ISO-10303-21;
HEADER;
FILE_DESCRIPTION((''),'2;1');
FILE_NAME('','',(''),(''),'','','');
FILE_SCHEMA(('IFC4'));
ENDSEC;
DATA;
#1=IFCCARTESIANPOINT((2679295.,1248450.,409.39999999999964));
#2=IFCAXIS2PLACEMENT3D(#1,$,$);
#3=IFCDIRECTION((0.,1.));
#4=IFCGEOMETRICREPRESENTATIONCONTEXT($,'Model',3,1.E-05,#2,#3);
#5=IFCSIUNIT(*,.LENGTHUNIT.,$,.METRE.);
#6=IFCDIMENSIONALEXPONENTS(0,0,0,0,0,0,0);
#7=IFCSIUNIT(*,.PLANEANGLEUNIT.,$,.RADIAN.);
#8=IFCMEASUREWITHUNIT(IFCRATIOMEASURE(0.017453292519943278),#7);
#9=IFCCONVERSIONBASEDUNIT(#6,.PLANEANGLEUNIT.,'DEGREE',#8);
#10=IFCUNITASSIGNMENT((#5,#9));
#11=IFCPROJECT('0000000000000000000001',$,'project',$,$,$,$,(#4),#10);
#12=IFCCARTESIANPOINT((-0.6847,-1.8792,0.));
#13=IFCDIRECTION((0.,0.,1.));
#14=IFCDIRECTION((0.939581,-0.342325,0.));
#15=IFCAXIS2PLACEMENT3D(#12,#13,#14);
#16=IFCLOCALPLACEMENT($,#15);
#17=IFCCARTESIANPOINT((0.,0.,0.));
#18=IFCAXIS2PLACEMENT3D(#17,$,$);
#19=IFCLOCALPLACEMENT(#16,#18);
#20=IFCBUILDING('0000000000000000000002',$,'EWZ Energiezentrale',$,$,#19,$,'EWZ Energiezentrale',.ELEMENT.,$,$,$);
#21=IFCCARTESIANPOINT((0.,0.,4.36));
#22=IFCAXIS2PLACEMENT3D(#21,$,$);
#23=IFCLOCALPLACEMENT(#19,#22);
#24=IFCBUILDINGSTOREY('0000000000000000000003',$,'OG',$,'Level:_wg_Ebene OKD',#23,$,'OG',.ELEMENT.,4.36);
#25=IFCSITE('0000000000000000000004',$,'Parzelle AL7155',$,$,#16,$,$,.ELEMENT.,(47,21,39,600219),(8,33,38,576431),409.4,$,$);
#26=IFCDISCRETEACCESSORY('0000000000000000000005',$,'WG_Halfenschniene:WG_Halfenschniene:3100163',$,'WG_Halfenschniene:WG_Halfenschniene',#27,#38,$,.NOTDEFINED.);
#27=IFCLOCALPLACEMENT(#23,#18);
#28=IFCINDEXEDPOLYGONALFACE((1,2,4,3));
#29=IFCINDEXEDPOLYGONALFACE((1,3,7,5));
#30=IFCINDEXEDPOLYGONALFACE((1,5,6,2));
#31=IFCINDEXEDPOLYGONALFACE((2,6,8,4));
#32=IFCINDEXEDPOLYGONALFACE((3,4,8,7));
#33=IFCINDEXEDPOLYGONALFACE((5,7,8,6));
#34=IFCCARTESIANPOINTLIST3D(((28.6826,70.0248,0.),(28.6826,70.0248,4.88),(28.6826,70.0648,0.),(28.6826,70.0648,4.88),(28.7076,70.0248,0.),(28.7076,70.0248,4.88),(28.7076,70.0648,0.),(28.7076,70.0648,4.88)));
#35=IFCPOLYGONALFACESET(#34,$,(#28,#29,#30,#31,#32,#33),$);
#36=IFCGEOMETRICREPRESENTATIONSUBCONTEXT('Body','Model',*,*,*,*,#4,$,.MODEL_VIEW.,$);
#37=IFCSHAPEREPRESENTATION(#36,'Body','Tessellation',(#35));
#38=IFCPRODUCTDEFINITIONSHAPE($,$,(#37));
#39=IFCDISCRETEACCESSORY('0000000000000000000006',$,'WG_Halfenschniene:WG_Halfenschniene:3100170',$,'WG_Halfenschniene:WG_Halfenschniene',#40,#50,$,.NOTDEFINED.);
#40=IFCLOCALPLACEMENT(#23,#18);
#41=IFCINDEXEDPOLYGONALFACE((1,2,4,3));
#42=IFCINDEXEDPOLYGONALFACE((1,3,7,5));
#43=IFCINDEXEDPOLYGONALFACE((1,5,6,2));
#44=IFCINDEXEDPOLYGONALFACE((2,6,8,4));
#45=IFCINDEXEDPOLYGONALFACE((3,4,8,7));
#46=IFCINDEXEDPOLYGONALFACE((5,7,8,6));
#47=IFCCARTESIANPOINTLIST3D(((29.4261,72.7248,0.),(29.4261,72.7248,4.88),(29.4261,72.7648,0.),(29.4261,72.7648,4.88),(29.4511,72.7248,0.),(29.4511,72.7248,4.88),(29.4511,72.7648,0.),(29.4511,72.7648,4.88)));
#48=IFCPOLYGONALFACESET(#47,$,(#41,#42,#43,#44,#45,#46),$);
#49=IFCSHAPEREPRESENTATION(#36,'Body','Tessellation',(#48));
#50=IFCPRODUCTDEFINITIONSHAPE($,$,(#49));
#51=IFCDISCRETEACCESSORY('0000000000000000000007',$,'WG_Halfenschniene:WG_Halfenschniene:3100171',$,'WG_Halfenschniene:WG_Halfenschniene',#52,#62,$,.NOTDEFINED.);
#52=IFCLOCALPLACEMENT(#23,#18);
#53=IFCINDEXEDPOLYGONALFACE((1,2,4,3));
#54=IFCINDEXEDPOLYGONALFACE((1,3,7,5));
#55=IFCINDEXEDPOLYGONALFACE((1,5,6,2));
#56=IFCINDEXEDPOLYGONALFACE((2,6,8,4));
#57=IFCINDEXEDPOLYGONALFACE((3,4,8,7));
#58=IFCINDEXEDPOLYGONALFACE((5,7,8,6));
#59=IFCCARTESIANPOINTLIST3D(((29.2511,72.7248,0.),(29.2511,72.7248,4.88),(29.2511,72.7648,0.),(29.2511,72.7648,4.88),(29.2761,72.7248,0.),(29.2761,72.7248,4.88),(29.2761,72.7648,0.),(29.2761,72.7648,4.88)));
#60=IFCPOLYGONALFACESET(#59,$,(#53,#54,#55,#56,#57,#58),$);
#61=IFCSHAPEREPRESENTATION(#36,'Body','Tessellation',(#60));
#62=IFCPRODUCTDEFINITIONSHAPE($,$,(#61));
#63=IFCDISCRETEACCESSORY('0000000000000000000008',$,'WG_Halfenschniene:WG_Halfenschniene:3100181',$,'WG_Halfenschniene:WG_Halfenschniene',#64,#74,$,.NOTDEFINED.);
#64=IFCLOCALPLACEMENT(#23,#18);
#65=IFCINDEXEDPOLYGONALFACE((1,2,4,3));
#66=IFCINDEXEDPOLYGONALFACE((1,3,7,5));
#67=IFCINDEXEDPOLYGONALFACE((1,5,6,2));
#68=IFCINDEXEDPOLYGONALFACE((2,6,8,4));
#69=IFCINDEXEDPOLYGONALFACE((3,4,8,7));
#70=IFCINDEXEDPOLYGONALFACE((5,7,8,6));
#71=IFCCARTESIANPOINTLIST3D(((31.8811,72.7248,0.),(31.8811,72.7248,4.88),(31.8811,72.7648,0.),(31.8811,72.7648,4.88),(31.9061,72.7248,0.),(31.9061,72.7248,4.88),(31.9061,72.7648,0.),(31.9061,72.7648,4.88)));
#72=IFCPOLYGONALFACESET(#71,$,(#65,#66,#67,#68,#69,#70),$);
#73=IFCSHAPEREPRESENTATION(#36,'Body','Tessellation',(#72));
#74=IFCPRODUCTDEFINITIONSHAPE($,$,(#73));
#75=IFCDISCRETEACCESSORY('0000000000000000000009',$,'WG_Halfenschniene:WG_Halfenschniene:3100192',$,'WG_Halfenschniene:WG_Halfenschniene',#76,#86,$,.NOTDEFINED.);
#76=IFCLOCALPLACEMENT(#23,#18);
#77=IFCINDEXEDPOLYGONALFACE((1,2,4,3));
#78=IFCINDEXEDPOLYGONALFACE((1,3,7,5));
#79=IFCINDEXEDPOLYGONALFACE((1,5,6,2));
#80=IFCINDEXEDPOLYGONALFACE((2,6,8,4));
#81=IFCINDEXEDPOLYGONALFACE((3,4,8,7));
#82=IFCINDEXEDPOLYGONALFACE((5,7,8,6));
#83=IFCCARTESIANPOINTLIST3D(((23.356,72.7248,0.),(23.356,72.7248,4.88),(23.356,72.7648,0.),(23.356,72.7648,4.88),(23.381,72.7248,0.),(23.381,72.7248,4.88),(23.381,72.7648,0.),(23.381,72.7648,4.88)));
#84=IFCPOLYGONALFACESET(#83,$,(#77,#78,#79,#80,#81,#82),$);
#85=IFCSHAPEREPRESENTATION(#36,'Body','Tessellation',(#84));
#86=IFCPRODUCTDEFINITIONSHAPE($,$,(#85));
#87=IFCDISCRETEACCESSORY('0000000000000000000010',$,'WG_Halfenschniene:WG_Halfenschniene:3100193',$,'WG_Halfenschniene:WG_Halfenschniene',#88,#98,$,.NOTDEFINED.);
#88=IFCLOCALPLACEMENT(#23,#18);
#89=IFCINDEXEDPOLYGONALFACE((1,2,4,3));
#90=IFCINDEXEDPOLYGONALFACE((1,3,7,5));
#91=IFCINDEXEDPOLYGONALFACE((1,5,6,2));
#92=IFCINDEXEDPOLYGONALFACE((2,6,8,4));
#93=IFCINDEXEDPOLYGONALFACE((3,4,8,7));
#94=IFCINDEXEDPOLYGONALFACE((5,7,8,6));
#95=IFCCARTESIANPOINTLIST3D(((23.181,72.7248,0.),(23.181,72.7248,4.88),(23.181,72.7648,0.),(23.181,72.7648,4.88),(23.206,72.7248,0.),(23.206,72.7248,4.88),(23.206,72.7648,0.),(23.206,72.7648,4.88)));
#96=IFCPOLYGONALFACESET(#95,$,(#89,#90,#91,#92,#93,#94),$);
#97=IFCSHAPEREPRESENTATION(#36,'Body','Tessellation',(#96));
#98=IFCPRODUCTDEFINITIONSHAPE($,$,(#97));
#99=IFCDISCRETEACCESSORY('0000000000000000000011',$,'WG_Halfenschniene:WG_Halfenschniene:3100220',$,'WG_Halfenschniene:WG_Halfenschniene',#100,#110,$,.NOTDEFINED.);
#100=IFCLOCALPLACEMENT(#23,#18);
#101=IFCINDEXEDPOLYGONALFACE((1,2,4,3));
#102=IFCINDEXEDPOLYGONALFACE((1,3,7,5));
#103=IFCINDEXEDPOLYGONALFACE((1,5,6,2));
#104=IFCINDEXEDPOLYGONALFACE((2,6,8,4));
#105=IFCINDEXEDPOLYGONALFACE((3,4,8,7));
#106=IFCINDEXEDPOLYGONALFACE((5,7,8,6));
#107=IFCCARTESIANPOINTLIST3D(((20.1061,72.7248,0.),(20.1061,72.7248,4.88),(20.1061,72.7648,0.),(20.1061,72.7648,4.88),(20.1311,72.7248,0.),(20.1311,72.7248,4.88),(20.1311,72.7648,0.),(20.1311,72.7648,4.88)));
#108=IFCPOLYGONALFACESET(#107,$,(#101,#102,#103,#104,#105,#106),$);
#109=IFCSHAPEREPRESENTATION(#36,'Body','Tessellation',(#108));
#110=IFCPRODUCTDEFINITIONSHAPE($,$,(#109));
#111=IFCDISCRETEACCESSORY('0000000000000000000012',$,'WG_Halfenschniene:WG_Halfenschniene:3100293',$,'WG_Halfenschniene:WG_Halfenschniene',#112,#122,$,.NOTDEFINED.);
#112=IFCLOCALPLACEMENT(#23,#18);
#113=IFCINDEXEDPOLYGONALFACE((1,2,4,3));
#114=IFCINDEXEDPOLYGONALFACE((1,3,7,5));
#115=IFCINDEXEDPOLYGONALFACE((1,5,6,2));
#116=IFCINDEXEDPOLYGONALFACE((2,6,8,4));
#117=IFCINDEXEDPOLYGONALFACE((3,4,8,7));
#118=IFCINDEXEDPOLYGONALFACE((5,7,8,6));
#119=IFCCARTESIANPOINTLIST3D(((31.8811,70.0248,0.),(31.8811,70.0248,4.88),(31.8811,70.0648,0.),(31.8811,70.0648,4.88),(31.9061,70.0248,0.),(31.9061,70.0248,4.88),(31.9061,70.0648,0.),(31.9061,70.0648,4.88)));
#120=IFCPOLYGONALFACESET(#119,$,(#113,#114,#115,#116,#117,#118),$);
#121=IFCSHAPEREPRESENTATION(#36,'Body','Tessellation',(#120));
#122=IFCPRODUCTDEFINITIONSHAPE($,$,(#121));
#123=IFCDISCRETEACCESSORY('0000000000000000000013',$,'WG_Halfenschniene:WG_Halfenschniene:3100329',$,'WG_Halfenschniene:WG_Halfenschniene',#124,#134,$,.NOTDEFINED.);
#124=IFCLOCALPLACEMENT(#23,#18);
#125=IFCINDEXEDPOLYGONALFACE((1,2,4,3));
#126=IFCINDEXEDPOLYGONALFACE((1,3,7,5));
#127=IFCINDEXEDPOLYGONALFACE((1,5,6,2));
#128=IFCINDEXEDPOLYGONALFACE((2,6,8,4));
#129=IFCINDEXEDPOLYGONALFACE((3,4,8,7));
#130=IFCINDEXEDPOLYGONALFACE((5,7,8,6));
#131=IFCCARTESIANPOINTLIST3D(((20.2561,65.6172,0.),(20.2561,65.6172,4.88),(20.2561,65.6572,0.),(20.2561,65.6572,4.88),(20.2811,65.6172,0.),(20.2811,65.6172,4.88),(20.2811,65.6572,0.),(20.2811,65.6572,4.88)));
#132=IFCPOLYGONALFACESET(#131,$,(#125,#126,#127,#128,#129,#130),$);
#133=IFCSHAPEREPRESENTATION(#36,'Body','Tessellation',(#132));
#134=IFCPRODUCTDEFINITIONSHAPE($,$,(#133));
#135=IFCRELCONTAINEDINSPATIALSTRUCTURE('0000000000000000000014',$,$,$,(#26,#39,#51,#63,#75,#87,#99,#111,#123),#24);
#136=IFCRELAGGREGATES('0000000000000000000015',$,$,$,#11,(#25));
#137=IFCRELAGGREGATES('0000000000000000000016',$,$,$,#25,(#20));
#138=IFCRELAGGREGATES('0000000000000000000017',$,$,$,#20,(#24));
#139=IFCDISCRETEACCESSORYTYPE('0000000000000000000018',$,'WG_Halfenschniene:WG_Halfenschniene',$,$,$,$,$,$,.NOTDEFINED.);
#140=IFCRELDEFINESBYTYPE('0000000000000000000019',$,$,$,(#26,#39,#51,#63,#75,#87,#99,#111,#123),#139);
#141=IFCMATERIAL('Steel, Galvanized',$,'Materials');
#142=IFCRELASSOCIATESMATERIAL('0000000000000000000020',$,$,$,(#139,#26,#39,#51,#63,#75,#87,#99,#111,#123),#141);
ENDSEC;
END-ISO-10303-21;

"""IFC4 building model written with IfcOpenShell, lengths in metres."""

from ifc_helpers import new_model, entity, si_unit, converted_unit, direction, frame, origin, place, context, subcontext, project, spatial, indexed_curve, outline, extrude, source, transform, mapped, material, type_object, element, save


model = new_model("IFC4")

# Units and contexts
model_context = context("Model", 3, precision=1e-05, world=frame((2679295.0, 1248450.0, 409.39999999999964)), true_north=direction((0.0, 1.0)))
body_context = subcontext(model_context, "Body", "Model", "MODEL_VIEW")
ifc_project = project(units=[si_unit("LENGTHUNIT", "METRE"), converted_unit("PLANEANGLEUNIT", "DEGREE", entity("IfcRatioMeasure", 0.017453292519943278), si_unit("PLANEANGLEUNIT", "RADIAN"), dimensions=[0, 0, 0, 0, 0, 0, 0])], contexts=[model_context])

# Site, building, storey
site_placement = place(None, frame((-0.6847, -1.8792, 0.0), z_axis=(0.0, 0.0, 1.0), x_axis=(0.939581, -0.342325, 0.0)))
site = spatial("IfcSite", under=ifc_project, at=site_placement, Name="Parzelle AL7155", CompositionType="ELEMENT", RefLatitude=(47, 21, 39, 600219), RefLongitude=(8, 33, 38, 576431), RefElevation=409.4)
building_placement = place(site_placement, origin())
building = spatial("IfcBuilding", under=site, at=building_placement, Name="EWZ Energiezentrale", LongName="EWZ Energiezentrale", CompositionType="ELEMENT")
storey_placement = place(building_placement, frame((0.0, 0.0, 4.36)))
storey = spatial("IfcBuildingStorey", under=building, at=storey_placement, Name="OG", ObjectType="Level:_wg_Ebene OKD", LongName="OG", CompositionType="ELEMENT", Elevation=4.36)

# Discrete accessories
ifc_material_1 = material(Name="Steel, Galvanized", Category="Materials")
discrete_accessory_type = type_object("IfcDiscreteAccessoryType", Name="WG_Halfenschniene:WG_Halfenschniene", PredefinedType="NOTDEFINED", material=ifc_material_1)
shared_shape_1 = source(origin(), body_context, "Body", "SweptSolid", [
    extrude(outline(indexed_curve([(-2.44, -0.02), (2.44, -0.02), (2.44, 0.02), (-2.44, 0.02), (-2.44, -0.02)], self_intersect=False)), frame((2.44, 0.0, -0.0125)), (0.0, 0.0, 1.0), 0.025),
])
for number, where, z_axis, x_axis, name in (
    (1, (28.6951, 70.0448, 0.0), (-1.0, 0.0, 0.0), (0.0, 0.0, 1.0), "WG_Halfenschniene:WG_Halfenschniene:3100163"),
    (2, (29.4386, 72.7448, 4.88), (1.0, 0.0, 0.0), (0.0, 0.0, -1.0), "WG_Halfenschniene:WG_Halfenschniene:3100170"),
    (3, (29.2636, 72.7448, 0.0), (-1.0, 0.0, 0.0), (0.0, 0.0, 1.0), "WG_Halfenschniene:WG_Halfenschniene:3100171"),
    (4, (31.8936, 72.7448, 0.0), (-1.0, 0.0, 0.0), (0.0, 0.0, 1.0), "WG_Halfenschniene:WG_Halfenschniene:3100181"),
    (5, (23.3685, 72.7448, 4.88), (1.0, 0.0, 0.0), (0.0, 0.0, -1.0), "WG_Halfenschniene:WG_Halfenschniene:3100192"),
    (6, (23.1935, 72.7448, 0.0), (-1.0, 0.0, 0.0), (0.0, 0.0, 1.0), "WG_Halfenschniene:WG_Halfenschniene:3100193"),
    (7, (20.1186, 72.7448, 4.88), (-1.0, 0.0, 0.0), (0.0, 0.0, -1.0), "WG_Halfenschniene:WG_Halfenschniene:3100220"),
    (8, (31.8936, 70.0448, 4.88), (1.0, 0.0, 0.0), (0.0, 0.0, -1.0), "WG_Halfenschniene:WG_Halfenschniene:3100293"),
    (9, (20.2686, 65.6372, 0.0), (-1.0, 0.0, 0.0), (0.0, 0.0, 1.0), "WG_Halfenschniene:WG_Halfenschniene:3100329"),
):
    element("IfcDiscreteAccessory", number, at=place(storey_placement, frame(where, z_axis=z_axis, x_axis=x_axis)), inside=storey, type_object=discrete_accessory_type, material=ifc_material_1, Name=name, ObjectType="WG_Halfenschniene:WG_Halfenschniene", PredefinedType="NOTDEFINED", context=body_context, shape_type="MappedRepresentation", body=[
        mapped(shared_shape_1, transform((0.0, 0.0, 0.0), scale=1.0)),
    ])

save(model, "model.ifc")
